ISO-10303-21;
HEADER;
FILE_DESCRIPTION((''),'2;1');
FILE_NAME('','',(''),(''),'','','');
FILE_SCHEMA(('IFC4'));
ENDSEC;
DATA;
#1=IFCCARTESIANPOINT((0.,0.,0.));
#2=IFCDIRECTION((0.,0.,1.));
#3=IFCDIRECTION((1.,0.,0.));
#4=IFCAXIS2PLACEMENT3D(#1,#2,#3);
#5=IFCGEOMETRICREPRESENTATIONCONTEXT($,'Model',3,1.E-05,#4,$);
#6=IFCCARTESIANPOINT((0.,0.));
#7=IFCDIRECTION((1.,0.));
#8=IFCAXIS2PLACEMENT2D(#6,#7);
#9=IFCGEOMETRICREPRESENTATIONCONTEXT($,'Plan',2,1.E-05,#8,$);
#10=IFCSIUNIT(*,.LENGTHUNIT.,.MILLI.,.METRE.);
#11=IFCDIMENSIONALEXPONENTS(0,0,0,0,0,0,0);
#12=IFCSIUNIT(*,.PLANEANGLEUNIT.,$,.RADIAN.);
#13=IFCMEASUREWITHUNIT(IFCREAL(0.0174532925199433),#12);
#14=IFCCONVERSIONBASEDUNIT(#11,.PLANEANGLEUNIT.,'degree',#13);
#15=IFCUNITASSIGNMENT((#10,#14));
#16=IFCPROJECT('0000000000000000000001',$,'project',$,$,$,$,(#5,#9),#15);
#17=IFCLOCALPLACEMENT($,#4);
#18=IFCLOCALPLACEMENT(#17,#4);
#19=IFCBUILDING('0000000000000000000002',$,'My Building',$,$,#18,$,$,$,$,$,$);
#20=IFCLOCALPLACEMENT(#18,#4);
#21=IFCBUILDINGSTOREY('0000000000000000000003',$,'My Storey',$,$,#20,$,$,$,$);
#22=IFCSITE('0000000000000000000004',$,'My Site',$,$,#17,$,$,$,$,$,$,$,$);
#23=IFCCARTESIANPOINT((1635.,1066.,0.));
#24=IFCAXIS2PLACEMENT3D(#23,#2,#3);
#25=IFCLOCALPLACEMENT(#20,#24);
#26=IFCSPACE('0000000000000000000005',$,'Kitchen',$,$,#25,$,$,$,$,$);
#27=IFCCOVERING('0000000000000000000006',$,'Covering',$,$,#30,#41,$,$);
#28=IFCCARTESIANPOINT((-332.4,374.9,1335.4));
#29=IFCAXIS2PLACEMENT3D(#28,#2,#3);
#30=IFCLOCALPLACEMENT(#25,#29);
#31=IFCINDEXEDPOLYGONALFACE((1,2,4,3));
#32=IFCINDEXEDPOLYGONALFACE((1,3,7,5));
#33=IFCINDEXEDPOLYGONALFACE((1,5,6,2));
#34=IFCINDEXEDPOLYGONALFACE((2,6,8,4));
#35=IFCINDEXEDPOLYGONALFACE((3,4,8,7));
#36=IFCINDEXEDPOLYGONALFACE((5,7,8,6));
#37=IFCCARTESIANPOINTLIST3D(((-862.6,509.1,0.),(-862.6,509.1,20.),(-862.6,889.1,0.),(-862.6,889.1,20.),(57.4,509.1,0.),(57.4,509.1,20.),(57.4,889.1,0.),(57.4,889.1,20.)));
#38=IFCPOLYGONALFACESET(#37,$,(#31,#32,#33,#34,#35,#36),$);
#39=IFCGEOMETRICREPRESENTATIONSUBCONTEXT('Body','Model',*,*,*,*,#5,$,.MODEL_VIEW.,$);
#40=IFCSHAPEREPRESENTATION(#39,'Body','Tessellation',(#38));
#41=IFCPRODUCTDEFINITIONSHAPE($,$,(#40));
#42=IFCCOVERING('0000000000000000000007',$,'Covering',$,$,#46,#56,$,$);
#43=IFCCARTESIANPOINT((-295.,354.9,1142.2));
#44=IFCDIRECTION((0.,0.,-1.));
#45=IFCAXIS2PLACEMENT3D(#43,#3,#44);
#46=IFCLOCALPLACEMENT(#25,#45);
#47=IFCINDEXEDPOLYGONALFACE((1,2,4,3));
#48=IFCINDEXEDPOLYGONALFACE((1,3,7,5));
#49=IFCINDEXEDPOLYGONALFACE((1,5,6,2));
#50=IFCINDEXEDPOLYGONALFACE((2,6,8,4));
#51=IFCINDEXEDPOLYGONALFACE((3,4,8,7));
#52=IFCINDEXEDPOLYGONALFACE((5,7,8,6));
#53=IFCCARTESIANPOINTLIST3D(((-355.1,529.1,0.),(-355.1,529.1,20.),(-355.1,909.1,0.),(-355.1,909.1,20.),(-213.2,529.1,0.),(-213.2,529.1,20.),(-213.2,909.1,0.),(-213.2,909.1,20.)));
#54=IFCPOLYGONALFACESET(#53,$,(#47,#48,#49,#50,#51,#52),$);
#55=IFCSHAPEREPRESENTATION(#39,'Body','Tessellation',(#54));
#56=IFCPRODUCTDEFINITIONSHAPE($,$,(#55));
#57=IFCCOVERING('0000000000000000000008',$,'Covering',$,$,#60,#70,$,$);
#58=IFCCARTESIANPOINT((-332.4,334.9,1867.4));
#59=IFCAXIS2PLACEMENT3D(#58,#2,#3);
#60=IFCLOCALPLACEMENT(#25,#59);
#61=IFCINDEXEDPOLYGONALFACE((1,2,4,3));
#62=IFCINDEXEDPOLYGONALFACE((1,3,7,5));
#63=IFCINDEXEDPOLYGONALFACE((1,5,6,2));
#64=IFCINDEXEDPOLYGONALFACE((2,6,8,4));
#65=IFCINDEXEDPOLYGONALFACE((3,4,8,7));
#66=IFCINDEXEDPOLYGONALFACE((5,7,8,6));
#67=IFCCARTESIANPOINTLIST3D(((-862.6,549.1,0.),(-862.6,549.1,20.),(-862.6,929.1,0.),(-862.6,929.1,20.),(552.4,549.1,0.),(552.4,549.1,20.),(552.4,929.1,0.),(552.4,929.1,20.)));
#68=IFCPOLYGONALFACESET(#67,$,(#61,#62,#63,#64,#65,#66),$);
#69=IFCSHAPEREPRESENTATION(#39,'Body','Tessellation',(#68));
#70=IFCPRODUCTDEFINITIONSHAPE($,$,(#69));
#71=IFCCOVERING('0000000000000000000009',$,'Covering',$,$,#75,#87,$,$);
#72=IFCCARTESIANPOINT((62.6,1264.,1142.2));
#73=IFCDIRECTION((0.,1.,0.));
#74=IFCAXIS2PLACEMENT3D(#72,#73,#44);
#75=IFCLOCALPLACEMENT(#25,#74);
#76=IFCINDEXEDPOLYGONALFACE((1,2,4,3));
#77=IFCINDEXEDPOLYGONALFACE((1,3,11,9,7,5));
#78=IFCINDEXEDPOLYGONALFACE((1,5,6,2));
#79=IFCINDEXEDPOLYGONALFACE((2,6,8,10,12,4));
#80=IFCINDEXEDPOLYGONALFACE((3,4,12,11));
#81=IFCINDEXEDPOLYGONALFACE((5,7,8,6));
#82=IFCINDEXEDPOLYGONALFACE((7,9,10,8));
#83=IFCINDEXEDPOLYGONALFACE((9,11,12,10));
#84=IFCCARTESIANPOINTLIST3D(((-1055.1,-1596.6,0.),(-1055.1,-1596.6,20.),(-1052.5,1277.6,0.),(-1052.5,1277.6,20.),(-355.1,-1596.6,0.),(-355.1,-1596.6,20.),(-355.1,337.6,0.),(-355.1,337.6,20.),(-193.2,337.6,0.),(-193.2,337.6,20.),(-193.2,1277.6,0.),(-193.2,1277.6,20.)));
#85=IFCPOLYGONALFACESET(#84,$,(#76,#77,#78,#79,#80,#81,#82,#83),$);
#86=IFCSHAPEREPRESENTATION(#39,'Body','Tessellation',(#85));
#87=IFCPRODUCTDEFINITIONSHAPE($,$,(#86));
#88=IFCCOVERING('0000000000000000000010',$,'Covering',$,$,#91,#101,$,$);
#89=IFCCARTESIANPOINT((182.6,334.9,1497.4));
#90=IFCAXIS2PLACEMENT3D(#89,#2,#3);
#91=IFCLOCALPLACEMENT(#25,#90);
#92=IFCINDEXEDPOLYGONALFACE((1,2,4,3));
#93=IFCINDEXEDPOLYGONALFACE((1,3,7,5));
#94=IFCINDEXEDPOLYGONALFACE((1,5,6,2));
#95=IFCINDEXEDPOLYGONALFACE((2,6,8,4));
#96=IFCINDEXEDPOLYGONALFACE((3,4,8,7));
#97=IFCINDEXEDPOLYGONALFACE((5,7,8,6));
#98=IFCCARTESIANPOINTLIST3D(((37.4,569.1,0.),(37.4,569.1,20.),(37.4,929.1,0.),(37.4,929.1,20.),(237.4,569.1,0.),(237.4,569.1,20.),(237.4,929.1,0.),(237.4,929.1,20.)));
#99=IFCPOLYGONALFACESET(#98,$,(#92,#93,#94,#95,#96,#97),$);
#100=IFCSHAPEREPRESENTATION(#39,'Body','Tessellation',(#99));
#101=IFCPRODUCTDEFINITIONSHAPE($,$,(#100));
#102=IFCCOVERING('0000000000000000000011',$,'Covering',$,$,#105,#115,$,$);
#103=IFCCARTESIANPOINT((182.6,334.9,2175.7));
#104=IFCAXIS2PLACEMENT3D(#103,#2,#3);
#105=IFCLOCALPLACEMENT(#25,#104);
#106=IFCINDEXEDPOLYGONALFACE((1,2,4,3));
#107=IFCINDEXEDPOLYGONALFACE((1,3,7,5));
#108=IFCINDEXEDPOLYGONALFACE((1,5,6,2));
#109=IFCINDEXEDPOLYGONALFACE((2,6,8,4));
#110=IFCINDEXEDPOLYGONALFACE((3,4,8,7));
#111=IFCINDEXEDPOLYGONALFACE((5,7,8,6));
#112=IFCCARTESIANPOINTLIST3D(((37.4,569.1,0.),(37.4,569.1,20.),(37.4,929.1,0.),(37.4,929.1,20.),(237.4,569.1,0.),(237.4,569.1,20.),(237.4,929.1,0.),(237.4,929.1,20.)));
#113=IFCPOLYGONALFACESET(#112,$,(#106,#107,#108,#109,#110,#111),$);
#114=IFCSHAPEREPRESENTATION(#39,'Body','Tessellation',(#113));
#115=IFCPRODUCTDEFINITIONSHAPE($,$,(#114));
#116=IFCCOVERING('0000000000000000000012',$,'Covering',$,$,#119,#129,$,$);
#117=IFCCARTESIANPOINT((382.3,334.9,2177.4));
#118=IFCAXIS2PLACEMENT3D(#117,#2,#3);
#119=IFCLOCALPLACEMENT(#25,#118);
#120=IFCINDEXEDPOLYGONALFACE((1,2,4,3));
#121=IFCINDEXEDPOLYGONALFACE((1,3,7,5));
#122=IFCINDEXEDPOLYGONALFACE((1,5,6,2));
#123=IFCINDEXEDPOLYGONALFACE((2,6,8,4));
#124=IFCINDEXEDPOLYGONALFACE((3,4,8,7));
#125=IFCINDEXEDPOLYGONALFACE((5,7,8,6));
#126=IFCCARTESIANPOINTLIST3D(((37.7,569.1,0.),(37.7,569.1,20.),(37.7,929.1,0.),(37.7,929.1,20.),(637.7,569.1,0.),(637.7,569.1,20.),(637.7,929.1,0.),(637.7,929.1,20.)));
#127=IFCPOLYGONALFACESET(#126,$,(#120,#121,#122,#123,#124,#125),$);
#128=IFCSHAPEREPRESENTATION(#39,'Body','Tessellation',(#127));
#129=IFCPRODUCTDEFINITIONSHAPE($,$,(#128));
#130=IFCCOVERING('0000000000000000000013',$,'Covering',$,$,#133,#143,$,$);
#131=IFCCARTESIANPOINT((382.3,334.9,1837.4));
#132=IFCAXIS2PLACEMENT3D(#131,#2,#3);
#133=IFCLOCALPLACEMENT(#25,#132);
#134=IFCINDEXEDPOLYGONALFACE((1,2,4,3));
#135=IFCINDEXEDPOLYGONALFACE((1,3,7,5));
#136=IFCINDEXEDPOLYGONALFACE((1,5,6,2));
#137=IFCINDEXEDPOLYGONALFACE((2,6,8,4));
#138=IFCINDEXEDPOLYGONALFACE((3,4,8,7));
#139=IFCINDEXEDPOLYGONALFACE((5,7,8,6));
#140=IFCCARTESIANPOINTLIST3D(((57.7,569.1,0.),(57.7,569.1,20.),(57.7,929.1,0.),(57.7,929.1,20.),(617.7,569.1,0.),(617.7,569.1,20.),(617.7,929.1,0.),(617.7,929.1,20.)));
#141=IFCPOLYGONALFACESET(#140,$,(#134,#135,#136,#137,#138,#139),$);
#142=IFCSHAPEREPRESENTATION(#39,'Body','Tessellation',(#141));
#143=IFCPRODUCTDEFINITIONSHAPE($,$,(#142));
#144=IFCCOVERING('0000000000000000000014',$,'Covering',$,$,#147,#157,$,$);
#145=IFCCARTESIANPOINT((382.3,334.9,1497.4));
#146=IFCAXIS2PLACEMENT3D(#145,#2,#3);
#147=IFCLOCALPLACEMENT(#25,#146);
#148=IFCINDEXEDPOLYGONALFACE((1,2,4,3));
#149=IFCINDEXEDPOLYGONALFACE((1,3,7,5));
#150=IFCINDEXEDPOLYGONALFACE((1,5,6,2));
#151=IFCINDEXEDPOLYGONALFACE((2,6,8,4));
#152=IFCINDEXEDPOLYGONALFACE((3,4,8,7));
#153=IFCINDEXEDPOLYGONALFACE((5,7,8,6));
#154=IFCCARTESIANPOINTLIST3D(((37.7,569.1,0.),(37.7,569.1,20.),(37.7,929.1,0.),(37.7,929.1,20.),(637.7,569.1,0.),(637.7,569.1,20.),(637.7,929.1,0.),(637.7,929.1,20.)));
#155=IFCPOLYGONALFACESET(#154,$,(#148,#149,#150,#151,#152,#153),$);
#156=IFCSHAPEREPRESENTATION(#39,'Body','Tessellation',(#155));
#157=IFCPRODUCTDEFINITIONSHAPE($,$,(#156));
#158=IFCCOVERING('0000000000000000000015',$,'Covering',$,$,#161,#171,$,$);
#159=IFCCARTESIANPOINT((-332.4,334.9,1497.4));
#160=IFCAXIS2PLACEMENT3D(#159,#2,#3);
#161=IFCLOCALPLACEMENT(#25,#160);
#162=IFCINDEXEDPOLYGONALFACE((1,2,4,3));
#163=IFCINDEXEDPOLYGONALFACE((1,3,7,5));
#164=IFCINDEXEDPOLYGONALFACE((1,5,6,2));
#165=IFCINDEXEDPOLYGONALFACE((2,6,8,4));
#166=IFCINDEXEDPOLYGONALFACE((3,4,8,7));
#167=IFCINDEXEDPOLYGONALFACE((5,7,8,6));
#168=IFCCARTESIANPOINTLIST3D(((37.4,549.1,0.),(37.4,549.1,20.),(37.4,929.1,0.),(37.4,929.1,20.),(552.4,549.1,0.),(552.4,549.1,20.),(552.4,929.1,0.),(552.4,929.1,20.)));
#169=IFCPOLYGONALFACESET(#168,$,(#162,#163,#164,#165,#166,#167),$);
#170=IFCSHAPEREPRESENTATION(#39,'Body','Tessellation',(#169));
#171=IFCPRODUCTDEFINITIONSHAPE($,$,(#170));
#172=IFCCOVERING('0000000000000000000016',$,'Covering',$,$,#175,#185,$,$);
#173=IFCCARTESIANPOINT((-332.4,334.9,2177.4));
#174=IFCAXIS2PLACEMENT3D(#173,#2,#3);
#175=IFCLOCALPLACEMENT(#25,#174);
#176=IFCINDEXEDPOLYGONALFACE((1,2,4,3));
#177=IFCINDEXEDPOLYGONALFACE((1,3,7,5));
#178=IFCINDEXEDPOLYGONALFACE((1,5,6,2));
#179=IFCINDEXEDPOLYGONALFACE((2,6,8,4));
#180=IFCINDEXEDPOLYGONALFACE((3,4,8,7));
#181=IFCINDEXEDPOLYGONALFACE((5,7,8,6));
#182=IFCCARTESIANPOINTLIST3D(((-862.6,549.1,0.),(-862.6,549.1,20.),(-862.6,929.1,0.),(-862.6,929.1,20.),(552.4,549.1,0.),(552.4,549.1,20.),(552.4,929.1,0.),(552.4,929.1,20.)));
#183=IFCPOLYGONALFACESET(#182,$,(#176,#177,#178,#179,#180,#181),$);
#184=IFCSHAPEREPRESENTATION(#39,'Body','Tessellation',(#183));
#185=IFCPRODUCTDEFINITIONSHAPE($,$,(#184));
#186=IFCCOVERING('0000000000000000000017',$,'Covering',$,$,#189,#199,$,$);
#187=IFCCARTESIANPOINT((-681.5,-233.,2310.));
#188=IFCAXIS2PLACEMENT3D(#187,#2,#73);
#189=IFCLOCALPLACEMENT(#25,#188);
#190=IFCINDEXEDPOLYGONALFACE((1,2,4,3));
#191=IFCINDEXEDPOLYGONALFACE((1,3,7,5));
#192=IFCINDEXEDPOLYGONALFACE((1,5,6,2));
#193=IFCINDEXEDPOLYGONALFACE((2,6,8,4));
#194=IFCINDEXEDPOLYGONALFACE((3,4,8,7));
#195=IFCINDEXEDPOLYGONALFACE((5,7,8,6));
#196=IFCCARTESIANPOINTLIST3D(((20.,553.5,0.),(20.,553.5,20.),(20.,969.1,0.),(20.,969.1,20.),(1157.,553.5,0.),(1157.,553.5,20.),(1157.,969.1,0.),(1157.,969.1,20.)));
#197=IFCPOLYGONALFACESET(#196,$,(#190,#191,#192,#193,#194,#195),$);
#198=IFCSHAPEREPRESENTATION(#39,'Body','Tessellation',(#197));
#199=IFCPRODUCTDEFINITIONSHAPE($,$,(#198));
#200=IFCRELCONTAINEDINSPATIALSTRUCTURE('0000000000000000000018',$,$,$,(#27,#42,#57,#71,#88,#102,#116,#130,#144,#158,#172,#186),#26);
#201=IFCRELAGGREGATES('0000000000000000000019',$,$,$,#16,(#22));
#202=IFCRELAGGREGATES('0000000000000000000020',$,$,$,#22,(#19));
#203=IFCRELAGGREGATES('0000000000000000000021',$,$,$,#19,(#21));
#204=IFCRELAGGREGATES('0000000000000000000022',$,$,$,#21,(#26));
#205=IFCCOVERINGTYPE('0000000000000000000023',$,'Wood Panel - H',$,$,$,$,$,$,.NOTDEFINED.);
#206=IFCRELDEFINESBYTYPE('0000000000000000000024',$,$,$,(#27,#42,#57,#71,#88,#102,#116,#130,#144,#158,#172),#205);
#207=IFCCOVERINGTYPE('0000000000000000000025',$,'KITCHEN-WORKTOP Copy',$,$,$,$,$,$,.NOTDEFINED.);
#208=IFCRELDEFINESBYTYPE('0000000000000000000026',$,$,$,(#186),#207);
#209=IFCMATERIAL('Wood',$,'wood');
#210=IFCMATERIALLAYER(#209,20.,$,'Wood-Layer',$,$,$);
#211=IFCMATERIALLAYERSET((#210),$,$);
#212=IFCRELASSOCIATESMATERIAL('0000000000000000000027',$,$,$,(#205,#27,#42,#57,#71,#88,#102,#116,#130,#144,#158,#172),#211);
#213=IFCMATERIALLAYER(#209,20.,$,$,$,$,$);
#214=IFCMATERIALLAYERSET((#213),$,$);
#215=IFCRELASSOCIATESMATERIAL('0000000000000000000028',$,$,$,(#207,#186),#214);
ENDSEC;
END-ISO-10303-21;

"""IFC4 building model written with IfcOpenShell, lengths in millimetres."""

from ifc_helpers import new_model, entity, si_unit, converted_unit, frame, origin_with_axes, origin_2d_with_axis, place, context, subcontext, project, spatial, indexed_curve, outline, extrude, material, layer, layer_set, layer_usage, type_object, element, save


model = new_model("IFC4")

# Units and contexts
model_context = context("Model", 3, precision=1e-05, world=origin_with_axes())
plan_context = context("Plan", 2, precision=1e-05, world=origin_2d_with_axis())
body_context = subcontext(model_context, "Body", "Model", "MODEL_VIEW")
ifc_project = project(units=[si_unit("LENGTHUNIT", "METRE", prefix="MILLI"), converted_unit("PLANEANGLEUNIT", "degree", entity("IfcReal", 0.0174532925199433), si_unit("PLANEANGLEUNIT", "RADIAN"), dimensions=[0, 0, 0, 0, 0, 0, 0])], contexts=[model_context, plan_context])

# Site, building, storey, space
site_placement = place(None, origin_with_axes())
site = spatial("IfcSite", under=ifc_project, at=site_placement, Name="My Site")
building_placement = place(site_placement, origin_with_axes())
building = spatial("IfcBuilding", under=site, at=building_placement, Name="My Building")
storey_placement = place(building_placement, origin_with_axes())
storey = spatial("IfcBuildingStorey", under=building, at=storey_placement, Name="My Storey")
space_placement = place(storey_placement, frame((1635.0, 1066.0, 0.0), z_axis=(0.0, 0.0, 1.0), x_axis=(1.0, 0.0, 0.0)))
space = spatial("IfcSpace", under=storey, at=space_placement, Name="Kitchen")

# Coverings
ifc_material_1 = material(Name="Wood", Category="wood")
ifc_layer_1 = layer(ifc_material_1, 20.0, Name="Wood-Layer")
ifc_layer_set_1 = layer_set([ifc_layer_1])
ifc_layer_usage_1 = layer_usage(ifc_layer_set_1, "AXIS3", "POSITIVE", 0.0)
covering_type_1 = type_object("IfcCoveringType", Name="Wood Panel - H", PredefinedType="NOTDEFINED", material=ifc_layer_set_1)
covering_1_placement = place(space_placement, frame((-332.4, 374.9, 1335.4), z_axis=(0.0, 0.0, 1.0), x_axis=(1.0, 0.0, 0.0)))
element("IfcCovering", 1, at=covering_1_placement, inside=space, type_object=covering_type_1, material=ifc_layer_usage_1, Name="Covering", context=body_context, shape_type="SweptSolid", body=[
    extrude(outline(indexed_curve([(-862.6, 509.1), (-862.6, 889.1), (57.4, 889.1), (57.4, 509.1), (-862.6, 509.1)])), None, (0.0, 0.0, 1.0), 20.0),
])
ifc_layer_usage_2 = layer_usage(ifc_layer_set_1, "AXIS3", "POSITIVE", 0.0)
covering_2_placement = place(space_placement, frame((-295.0, 354.9, 1142.2), z_axis=(1.0, 0.0, 0.0), x_axis=(0.0, 0.0, -1.0)))
element("IfcCovering", 2, at=covering_2_placement, inside=space, type_object=covering_type_1, material=ifc_layer_usage_2, Name="Covering", context=body_context, shape_type="SweptSolid", body=[
    extrude(outline(indexed_curve([(-355.1, 529.1), (-355.1, 909.1), (-213.2, 909.1), (-213.2, 529.1), (-355.1, 529.1)])), None, (0.0, 0.0, 1.0), 20.0),
])
ifc_layer_usage_3 = layer_usage(ifc_layer_set_1, "AXIS3", "POSITIVE", 0.0)
covering_3_placement = place(space_placement, frame((-332.4, 334.9, 1867.4), z_axis=(0.0, 0.0, 1.0), x_axis=(1.0, 0.0, 0.0)))
element("IfcCovering", 3, at=covering_3_placement, inside=space, type_object=covering_type_1, material=ifc_layer_usage_3, Name="Covering", context=body_context, shape_type="SweptSolid", body=[
    extrude(outline(indexed_curve([(552.4, 549.1), (552.4, 929.1), (-862.6, 929.1), (-862.6, 549.1), (552.4, 549.1)])), None, (0.0, 0.0, 1.0), 20.0),
])
ifc_layer_usage_4 = layer_usage(ifc_layer_set_1, "AXIS3", "POSITIVE", 0.0)
covering_4_placement = place(space_placement, frame((62.6, 1264.0, 1142.2), z_axis=(0.0, 1.0, 0.0), x_axis=(0.0, 0.0, -1.0)))
element("IfcCovering", 4, at=covering_4_placement, inside=space, type_object=covering_type_1, material=ifc_layer_usage_4, Name="Covering", context=body_context, shape_type="SweptSolid", body=[
    extrude(outline(indexed_curve([(-193.2, 1277.6), (-1052.5, 1277.6), (-1055.1, -1596.6), (-355.1, -1596.6), (-355.1, 337.6), (-193.2, 337.6), (-193.2, 1277.6)])), None, (0.0, 0.0, 1.0), 20.0),
])
ifc_layer_usage_5 = layer_usage(ifc_layer_set_1, "AXIS3", "POSITIVE", 0.0)
covering_5_placement = place(space_placement, frame((182.6, 334.9, 1497.4), z_axis=(0.0, 0.0, 1.0), x_axis=(1.0, 0.0, 0.0)))
element("IfcCovering", 5, at=covering_5_placement, inside=space, type_object=covering_type_1, material=ifc_layer_usage_5, Name="Covering", context=body_context, shape_type="SweptSolid", body=[
    extrude(outline(indexed_curve([(237.4, 569.1), (237.4, 929.1), (37.4, 929.1), (37.4, 569.1), (237.4, 569.1)])), None, (0.0, 0.0, 1.0), 20.0),
])
ifc_layer_usage_6 = layer_usage(ifc_layer_set_1, "AXIS3", "POSITIVE", 0.0)
covering_6_placement = place(space_placement, frame((182.6, 334.9, 2175.7), z_axis=(0.0, 0.0, 1.0), x_axis=(1.0, 0.0, 0.0)))
element("IfcCovering", 6, at=covering_6_placement, inside=space, type_object=covering_type_1, material=ifc_layer_usage_6, Name="Covering", context=body_context, shape_type="SweptSolid", body=[
    extrude(outline(indexed_curve([(37.4, 569.1), (37.4, 929.1), (237.4, 929.1), (237.4, 569.1), (37.4, 569.1)])), None, (0.0, 0.0, 1.0), 20.0),
])
ifc_layer_usage_7 = layer_usage(ifc_layer_set_1, "AXIS3", "POSITIVE", 0.0)
covering_7_placement = place(space_placement, frame((382.3, 334.9, 2177.4), z_axis=(0.0, 0.0, 1.0), x_axis=(1.0, 0.0, 0.0)))
element("IfcCovering", 7, at=covering_7_placement, inside=space, type_object=covering_type_1, material=ifc_layer_usage_7, Name="Covering", context=body_context, shape_type="SweptSolid", body=[
    extrude(outline(indexed_curve([(37.7, 569.1), (37.7, 929.1), (637.7, 929.1), (637.7, 569.1), (37.7, 569.1)])), None, (0.0, 0.0, 1.0), 20.0),
])
ifc_layer_usage_8 = layer_usage(ifc_layer_set_1, "AXIS3", "POSITIVE", 0.0)
covering_8_placement = place(space_placement, frame((382.3, 334.9, 1837.4), z_axis=(0.0, 0.0, 1.0), x_axis=(1.0, 0.0, 0.0)))
element("IfcCovering", 8, at=covering_8_placement, inside=space, type_object=covering_type_1, material=ifc_layer_usage_8, Name="Covering", context=body_context, shape_type="SweptSolid", body=[
    extrude(outline(indexed_curve([(57.7, 569.1), (57.7, 929.1), (617.7, 929.1), (617.7, 569.1), (57.7, 569.1)])), None, (0.0, 0.0, 1.0), 20.0),
])
ifc_layer_usage_9 = layer_usage(ifc_layer_set_1, "AXIS3", "POSITIVE", 0.0)
covering_9_placement = place(space_placement, frame((382.3, 334.9, 1497.4), z_axis=(0.0, 0.0, 1.0), x_axis=(1.0, 0.0, 0.0)))
element("IfcCovering", 9, at=covering_9_placement, inside=space, type_object=covering_type_1, material=ifc_layer_usage_9, Name="Covering", context=body_context, shape_type="SweptSolid", body=[
    extrude(outline(indexed_curve([(637.7, 569.1), (637.7, 929.1), (37.7, 929.1), (37.7, 569.1), (637.7, 569.1)])), None, (0.0, 0.0, 1.0), 20.0),
])
ifc_layer_usage_10 = layer_usage(ifc_layer_set_1, "AXIS3", "POSITIVE", 0.0)
covering_10_placement = place(space_placement, frame((-332.4, 334.9, 1497.4), z_axis=(0.0, 0.0, 1.0), x_axis=(1.0, 0.0, 0.0)))
element("IfcCovering", 10, at=covering_10_placement, inside=space, type_object=covering_type_1, material=ifc_layer_usage_10, Name="Covering", context=body_context, shape_type="SweptSolid", body=[
    extrude(outline(indexed_curve([(37.4, 549.1), (37.4, 929.1), (552.4, 929.1), (552.4, 549.1), (37.4, 549.1)])), None, (0.0, 0.0, 1.0), 20.0),
])
ifc_layer_usage_11 = layer_usage(ifc_layer_set_1, "AXIS3", "POSITIVE", 0.0)
covering_11_placement = place(space_placement, frame((-332.4, 334.9, 2177.4), z_axis=(0.0, 0.0, 1.0), x_axis=(1.0, 0.0, 0.0)))
element("IfcCovering", 11, at=covering_11_placement, inside=space, type_object=covering_type_1, material=ifc_layer_usage_11, Name="Covering", context=body_context, shape_type="SweptSolid", body=[
    extrude(outline(indexed_curve([(552.4, 549.1), (552.4, 929.1), (-862.6, 929.1), (-862.6, 549.1), (552.4, 549.1)])), None, (0.0, 0.0, 1.0), 20.0),
])

# Covering
ifc_layer_2 = layer(ifc_material_1, 20.0)
ifc_layer_set_2 = layer_set([ifc_layer_2])
ifc_layer_usage_12 = layer_usage(ifc_layer_set_2, "AXIS3", "POSITIVE", 0.0)
covering_type_2 = type_object("IfcCoveringType", Name="KITCHEN-WORKTOP Copy", PredefinedType="NOTDEFINED", material=ifc_layer_set_2)
covering_12_placement = place(space_placement, frame((-681.5, -233.0, 2310.0), z_axis=(0.0, 0.0, 1.0), x_axis=(0.0, 1.0, 0.0)))
element("IfcCovering", 12, at=covering_12_placement, inside=space, type_object=covering_type_2, material=ifc_layer_usage_12, Name="Covering", context=body_context, shape_type="SweptSolid", body=[
    extrude(outline(indexed_curve([(20.0, 553.5), (20.0, 969.1), (1157.0, 969.1), (1157.0, 553.5), (20.0, 553.5)])), None, (0.0, 0.0, 1.0), 20.0),
])

save(model, "model.ifc")
